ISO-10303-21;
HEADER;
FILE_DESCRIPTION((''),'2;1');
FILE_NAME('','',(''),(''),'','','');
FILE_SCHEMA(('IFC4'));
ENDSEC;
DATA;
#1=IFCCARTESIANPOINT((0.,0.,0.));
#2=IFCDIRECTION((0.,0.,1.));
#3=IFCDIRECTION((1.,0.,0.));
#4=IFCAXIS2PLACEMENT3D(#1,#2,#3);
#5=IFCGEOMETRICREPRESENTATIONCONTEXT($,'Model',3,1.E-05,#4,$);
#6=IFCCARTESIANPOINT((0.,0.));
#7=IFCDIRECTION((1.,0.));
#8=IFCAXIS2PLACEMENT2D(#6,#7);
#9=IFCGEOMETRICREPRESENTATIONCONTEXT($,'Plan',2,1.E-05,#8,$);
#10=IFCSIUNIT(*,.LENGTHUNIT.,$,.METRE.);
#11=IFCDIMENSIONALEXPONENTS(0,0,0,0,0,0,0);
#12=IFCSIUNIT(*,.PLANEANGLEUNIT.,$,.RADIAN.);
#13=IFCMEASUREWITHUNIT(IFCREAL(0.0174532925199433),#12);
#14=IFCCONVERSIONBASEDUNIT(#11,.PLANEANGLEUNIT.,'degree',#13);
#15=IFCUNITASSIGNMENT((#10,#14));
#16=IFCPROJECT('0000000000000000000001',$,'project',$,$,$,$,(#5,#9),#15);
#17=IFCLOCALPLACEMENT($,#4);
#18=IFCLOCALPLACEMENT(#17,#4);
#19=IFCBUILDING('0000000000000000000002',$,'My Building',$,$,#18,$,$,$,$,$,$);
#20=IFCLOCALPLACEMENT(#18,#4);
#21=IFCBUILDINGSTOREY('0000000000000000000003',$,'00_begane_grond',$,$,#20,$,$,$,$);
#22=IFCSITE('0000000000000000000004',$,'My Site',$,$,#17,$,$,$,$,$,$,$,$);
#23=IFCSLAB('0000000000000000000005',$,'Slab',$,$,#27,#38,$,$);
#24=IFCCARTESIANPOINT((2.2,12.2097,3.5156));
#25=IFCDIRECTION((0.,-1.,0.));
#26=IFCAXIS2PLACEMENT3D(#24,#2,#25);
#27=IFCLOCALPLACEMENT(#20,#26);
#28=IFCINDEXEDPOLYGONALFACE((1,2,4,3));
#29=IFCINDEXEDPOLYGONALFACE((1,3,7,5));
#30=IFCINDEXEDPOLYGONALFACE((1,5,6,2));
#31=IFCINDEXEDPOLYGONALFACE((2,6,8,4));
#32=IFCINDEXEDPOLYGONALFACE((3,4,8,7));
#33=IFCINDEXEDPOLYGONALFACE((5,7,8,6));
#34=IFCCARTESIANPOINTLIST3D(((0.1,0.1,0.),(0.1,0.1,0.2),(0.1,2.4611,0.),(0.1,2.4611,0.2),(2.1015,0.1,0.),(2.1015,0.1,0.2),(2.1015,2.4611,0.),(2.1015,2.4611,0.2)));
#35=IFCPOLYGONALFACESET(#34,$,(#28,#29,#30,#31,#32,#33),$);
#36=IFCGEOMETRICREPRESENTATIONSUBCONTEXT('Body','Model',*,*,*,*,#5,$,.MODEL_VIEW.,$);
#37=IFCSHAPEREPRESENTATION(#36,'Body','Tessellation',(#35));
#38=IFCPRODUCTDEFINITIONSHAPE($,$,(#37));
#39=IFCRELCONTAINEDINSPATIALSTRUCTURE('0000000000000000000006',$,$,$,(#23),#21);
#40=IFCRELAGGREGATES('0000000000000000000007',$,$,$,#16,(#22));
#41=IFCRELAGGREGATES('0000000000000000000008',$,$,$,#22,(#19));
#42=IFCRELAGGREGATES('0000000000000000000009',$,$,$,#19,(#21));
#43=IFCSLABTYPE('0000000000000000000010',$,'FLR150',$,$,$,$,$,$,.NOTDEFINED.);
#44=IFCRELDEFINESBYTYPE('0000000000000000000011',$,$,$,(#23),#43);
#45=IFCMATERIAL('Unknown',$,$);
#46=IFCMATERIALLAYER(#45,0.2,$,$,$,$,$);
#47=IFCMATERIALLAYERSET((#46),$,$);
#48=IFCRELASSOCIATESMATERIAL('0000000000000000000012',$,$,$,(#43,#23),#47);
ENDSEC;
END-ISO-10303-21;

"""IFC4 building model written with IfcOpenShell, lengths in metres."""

from ifc_helpers import new_model, entity, si_unit, converted_unit, frame, origin_with_axes, origin_2d_with_axis, place, context, subcontext, project, spatial, line, indexed_curve, outline, extrude, material, layer, layer_set, layer_usage, type_object, element, save


model = new_model("IFC4")

# Units and contexts
model_context = context("Model", 3, precision=1e-05, world=origin_with_axes())
plan_context = context("Plan", 2, precision=1e-05, world=origin_2d_with_axis())
body_context = subcontext(model_context, "Body", "Model", "MODEL_VIEW")
ifc_project = project(units=[si_unit("LENGTHUNIT", "METRE"), converted_unit("PLANEANGLEUNIT", "degree", entity("IfcReal", 0.0174532925199433), si_unit("PLANEANGLEUNIT", "RADIAN"), dimensions=[0, 0, 0, 0, 0, 0, 0])], contexts=[model_context, plan_context])

# Site, building, storey
site_placement = place(None, origin_with_axes())
site = spatial("IfcSite", under=ifc_project, at=site_placement, Name="My Site")
building_placement = place(site_placement, origin_with_axes())
building = spatial("IfcBuilding", under=site, at=building_placement, Name="My Building")
storey_placement = place(building_placement, origin_with_axes())
storey = spatial("IfcBuildingStorey", under=building, at=storey_placement, Name="00_begane_grond")

# Slab
ifc_material = material(Name="Unknown")
ifc_layer_1 = layer(ifc_material, 0.2)
ifc_layer_set_1 = layer_set([ifc_layer_1])
slab_type = type_object("IfcSlabType", Name="FLR150", PredefinedType="NOTDEFINED", material=ifc_layer_set_1)
ifc_layer_usage_1 = layer_usage(ifc_layer_set_1, "AXIS3", "POSITIVE", 0.0)
slab_1_placement = place(storey_placement, frame((2.2, 12.2097, 3.5156), z_axis=(0.0, 0.0, 1.0), x_axis=(0.0, -1.0, 0.0)))
element("IfcSlab", 1, at=slab_1_placement, inside=storey, type_object=slab_type, material=ifc_layer_usage_1, Name="Slab", context=body_context, shape_type="SweptSolid", body=[
    extrude(outline(indexed_curve([(2.1015, 0.1), (0.1, 0.1), (0.1, 2.4611), (2.1015, 2.4611)], segments=[line(3, 2), line(2, 1), line(1, 4), line(4, 3)], self_intersect=False)), None, (0.0, 0.0, 1.0), 0.2),
])

save(model, "model.ifc")
